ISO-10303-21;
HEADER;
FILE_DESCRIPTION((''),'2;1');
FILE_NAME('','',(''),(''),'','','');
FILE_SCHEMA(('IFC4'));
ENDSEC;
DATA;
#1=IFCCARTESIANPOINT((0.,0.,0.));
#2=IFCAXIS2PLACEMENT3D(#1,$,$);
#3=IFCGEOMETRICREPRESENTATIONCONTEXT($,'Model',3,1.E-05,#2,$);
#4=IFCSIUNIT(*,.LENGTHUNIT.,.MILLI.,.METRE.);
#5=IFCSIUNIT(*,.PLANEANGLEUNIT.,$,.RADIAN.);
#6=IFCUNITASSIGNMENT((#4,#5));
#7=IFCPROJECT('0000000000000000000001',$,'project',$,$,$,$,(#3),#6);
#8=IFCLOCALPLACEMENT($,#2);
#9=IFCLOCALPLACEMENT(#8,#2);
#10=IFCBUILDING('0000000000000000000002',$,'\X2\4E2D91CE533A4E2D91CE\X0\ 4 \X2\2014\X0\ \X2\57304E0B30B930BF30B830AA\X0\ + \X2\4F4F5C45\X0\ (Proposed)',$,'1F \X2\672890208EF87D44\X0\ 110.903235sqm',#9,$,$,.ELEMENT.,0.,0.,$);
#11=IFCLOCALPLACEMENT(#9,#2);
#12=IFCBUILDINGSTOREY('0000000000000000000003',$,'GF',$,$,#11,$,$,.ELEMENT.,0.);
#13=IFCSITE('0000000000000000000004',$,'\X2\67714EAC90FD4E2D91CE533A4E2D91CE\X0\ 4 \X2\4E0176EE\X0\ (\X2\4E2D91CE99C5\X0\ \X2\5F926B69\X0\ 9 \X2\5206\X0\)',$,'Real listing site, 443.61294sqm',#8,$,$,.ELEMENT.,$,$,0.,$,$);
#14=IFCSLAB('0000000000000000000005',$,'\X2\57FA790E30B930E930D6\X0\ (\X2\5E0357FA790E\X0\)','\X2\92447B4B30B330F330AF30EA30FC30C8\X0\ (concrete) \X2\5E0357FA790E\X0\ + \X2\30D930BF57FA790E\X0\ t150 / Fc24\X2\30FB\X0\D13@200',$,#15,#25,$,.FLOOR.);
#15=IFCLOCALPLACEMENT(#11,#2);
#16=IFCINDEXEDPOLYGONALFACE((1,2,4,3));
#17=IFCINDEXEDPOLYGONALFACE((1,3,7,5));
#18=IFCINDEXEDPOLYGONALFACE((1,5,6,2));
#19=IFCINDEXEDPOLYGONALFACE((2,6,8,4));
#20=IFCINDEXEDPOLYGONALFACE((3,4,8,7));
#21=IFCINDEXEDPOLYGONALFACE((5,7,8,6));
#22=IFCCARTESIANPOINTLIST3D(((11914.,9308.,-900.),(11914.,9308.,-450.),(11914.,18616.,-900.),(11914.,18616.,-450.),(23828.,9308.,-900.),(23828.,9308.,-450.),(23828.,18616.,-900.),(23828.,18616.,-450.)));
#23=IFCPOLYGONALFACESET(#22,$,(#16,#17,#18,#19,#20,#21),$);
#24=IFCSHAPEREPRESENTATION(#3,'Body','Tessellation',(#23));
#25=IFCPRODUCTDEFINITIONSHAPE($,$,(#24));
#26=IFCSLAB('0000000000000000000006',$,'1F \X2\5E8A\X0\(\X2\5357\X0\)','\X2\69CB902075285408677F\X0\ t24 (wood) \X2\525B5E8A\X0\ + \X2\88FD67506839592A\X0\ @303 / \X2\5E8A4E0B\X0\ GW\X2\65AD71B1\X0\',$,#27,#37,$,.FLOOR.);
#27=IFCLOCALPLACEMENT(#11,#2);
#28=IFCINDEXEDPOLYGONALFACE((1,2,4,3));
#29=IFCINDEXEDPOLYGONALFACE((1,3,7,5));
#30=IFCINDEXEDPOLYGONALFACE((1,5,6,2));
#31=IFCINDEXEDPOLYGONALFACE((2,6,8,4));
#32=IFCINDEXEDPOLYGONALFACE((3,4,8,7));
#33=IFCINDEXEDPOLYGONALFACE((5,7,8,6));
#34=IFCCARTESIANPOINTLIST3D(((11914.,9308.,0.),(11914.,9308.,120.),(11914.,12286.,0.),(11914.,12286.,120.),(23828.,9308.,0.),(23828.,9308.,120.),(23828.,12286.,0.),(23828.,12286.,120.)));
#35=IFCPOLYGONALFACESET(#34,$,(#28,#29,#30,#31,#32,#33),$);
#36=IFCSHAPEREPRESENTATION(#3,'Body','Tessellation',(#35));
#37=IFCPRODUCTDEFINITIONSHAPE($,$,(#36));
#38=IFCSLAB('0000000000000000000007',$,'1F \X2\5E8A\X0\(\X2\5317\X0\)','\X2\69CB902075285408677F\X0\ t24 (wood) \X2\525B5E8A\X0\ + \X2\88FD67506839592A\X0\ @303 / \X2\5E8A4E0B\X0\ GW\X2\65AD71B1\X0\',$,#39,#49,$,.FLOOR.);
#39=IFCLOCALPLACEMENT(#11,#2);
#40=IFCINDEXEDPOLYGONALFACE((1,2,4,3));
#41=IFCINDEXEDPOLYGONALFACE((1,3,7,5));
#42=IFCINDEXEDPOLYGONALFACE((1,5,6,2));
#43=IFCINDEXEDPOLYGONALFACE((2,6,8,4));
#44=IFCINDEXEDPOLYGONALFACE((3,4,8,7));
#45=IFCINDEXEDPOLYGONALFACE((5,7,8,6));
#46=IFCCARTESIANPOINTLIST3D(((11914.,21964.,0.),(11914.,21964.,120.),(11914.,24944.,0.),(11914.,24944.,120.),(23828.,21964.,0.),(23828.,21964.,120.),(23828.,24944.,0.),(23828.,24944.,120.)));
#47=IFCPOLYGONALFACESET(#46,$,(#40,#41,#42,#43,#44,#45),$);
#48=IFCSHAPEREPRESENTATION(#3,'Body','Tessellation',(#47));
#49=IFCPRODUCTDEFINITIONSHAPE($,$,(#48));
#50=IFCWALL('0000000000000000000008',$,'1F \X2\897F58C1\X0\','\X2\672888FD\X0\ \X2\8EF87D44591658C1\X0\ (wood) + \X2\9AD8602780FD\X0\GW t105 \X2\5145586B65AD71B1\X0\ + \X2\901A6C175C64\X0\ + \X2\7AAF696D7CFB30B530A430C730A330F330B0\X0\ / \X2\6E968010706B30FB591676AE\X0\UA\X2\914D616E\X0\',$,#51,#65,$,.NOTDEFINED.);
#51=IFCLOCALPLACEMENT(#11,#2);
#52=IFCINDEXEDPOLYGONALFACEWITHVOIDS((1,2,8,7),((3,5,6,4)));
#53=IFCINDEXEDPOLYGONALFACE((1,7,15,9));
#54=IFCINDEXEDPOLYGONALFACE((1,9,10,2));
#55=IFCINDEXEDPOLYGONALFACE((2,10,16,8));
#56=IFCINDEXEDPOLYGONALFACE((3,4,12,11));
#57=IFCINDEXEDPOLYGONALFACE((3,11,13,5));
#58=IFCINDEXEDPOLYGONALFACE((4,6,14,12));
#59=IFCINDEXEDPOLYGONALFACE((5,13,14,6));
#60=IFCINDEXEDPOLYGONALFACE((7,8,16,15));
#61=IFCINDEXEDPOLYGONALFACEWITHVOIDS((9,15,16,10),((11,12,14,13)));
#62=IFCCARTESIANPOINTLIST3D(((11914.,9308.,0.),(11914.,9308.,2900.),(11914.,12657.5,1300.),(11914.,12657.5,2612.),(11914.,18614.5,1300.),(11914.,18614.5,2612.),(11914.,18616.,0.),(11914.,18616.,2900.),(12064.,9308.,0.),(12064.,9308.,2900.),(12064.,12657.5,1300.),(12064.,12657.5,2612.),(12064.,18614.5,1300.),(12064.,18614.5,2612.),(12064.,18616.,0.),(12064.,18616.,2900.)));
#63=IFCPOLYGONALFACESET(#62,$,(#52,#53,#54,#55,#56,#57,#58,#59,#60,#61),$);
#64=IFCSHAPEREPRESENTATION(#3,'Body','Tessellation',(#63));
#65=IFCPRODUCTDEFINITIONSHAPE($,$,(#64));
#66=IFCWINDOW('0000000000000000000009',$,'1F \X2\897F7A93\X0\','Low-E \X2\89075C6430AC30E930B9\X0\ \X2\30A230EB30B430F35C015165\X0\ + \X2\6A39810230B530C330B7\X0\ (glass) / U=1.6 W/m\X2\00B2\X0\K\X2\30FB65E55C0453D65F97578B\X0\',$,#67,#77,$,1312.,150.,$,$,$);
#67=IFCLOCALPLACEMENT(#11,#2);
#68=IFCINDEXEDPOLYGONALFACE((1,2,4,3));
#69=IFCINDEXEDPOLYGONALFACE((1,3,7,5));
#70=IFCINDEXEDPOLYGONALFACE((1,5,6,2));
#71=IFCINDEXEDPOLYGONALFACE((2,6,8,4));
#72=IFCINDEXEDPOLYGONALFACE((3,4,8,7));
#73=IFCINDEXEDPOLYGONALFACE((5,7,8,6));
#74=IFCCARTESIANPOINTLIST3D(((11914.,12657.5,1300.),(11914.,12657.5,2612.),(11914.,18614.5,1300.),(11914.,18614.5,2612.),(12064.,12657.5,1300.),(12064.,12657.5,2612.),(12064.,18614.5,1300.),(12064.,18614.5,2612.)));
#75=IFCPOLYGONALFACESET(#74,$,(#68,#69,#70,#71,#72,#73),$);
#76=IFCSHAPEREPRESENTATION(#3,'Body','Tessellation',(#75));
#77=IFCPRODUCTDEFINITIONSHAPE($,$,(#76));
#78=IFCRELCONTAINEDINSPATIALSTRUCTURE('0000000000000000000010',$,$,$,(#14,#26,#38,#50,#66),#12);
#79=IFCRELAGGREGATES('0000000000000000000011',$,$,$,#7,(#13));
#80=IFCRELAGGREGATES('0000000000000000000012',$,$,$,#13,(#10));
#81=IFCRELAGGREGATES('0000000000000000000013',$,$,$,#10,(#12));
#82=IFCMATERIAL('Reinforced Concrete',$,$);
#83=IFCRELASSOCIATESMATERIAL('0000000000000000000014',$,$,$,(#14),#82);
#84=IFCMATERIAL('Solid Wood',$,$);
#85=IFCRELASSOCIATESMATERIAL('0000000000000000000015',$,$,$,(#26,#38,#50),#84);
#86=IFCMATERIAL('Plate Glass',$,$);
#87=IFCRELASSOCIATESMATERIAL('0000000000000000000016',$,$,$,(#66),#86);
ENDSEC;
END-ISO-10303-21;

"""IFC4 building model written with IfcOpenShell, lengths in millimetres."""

from ifc_helpers import new_model, si_unit, frame, frame_2d, origin, place, context, project, spatial, rectangle, extrude, material, element, fill, save


model = new_model("IFC4")

# Units and contexts
model_context = context("Model", 3, precision=1e-05, world=origin())
ifc_project = project(units=[si_unit("LENGTHUNIT", "METRE", prefix="MILLI"), si_unit("PLANEANGLEUNIT", "RADIAN")], contexts=[model_context])

# Site, building, storey
site_placement = place(None, origin())
site = spatial("IfcSite", under=ifc_project, at=site_placement, Name="東京都中野区中野 4 丁目 (中野駅 徒歩 9 分)", ObjectType="Real listing site, 443.61294sqm", CompositionType="ELEMENT", RefElevation=0.0)
building_placement = place(site_placement, origin())
building = spatial("IfcBuilding", under=site, at=building_placement, Name="中野区中野 4 — 地下スタジオ + 住居 (Proposed)", ObjectType="1F 木造軸組 110.903235sqm", CompositionType="ELEMENT", ElevationOfRefHeight=0.0, ElevationOfTerrain=0.0)
storey_placement = place(building_placement, origin())
storey = spatial("IfcBuildingStorey", under=building, at=storey_placement, Name="GF", CompositionType="ELEMENT", Elevation=0.0)

# Slabs
ifc_material_1 = material(Name="Reinforced Concrete")
slab_1_placement = place(storey_placement, frame((5957.0, 4654.0, -450.0)))
element("IfcSlab", 1, at=slab_1_placement, inside=storey, material=ifc_material_1, Name="基礎スラブ (布基礎)", Description="鉄筋コンクリート (concrete) 布基礎 + ベタ基礎 t150 / Fc24・D13@200", PredefinedType="FLOOR", context=model_context, shape_type="SweptSolid", body=[
    extrude(rectangle(XDim=11914.0, YDim=9308.0, at=frame_2d((5957.0, 4654.0))), frame((5957.0, 4654.0, -450.0)), (0.0, 0.0, 1.0), 450.0),
])
ifc_material_2 = material(Name="Solid Wood")
slab_2_placement = place(storey_placement, frame((5957.0, 4654.0, 0.0)))
element("IfcSlab", 2, at=slab_2_placement, inside=storey, material=ifc_material_2, Name="1F 床(南)", Description="構造用合板 t24 (wood) 剛床 + 製材根太 @303 / 床下 GW断熱", PredefinedType="FLOOR", context=model_context, shape_type="SweptSolid", body=[
    extrude(rectangle(XDim=11914.0, YDim=2978.0, at=frame_2d((5957.0, 1489.0))), frame((5957.0, 4654.0, 0.0)), (0.0, 0.0, 1.0), 120.0),
])
slab_3_placement = place(storey_placement, frame((5957.0, 10982.0, 0.0)))
element("IfcSlab", 3, at=slab_3_placement, inside=storey, material=ifc_material_2, Name="1F 床(北)", Description="構造用合板 t24 (wood) 剛床 + 製材根太 @303 / 床下 GW断熱", PredefinedType="FLOOR", context=model_context, shape_type="SweptSolid", body=[
    extrude(rectangle(XDim=11914.0, YDim=2980.0, at=frame_2d((5957.0, 1490.0))), frame((5957.0, 10982.0, 0.0)), (0.0, 0.0, 1.0), 120.0),
])

# Shared definitions
ifc_material_3 = material(Name="Plate Glass")

# Wall, opening, window
wall_1_placement = place(storey_placement, frame((5957.0, 4654.0, 0.0)))
wall_1 = element("IfcWall", 4, at=wall_1_placement, inside=storey, material=ifc_material_2, Name="1F 西壁", Description="木製 軸組外壁 (wood) + 高性能GW t105 充填断熱 + 通気層 + 窯業系サイディング / 準耐火・外皮UA配慮", PredefinedType="NOTDEFINED", context=model_context, shape_type="SweptSolid", body=[
    extrude(rectangle(XDim=150.0, YDim=9308.0, at=frame_2d((75.0, 4654.0))), frame((5957.0, 4654.0, 0.0)), (0.0, 0.0, 1.0), 2900.0),
])
opening_1_placement = place(storey_placement, frame((5957.0, 6329.0, 650.0)))
opening_1 = element("IfcOpeningElement", 5, at=opening_1_placement, cuts=wall_1, PredefinedType="NOTDEFINED", context=model_context, shape_type="SweptSolid", body=[
    extrude(rectangle(XDim=150.0, YDim=5957.0, at=frame_2d((75.0, 2978.0))), frame((5957.0, 6329.0, 650.0)), (0.0, 0.0, 1.0), 1312.0),
])
window_1_placement = place(storey_placement, frame((5957.0, 6329.0, 650.0)))
window_1 = element("IfcWindow", 6, at=window_1_placement, inside=storey, material=ifc_material_3, Name="1F 西窓", Description="Low-E 複層ガラス アルゴン封入 + 樹脂サッシ (glass) / U=1.6 W/m²K・日射取得型", OverallHeight=1312.0, OverallWidth=150.0, context=model_context, shape_type="SweptSolid", body=[
    extrude(rectangle(XDim=150.0, YDim=5957.0, at=frame_2d((75.0, 2978.0))), frame((5957.0, 6329.0, 650.0)), (0.0, 0.0, 1.0), 1312.0),
])
fill(opening_1, window_1)

save(model, "model.ifc")
